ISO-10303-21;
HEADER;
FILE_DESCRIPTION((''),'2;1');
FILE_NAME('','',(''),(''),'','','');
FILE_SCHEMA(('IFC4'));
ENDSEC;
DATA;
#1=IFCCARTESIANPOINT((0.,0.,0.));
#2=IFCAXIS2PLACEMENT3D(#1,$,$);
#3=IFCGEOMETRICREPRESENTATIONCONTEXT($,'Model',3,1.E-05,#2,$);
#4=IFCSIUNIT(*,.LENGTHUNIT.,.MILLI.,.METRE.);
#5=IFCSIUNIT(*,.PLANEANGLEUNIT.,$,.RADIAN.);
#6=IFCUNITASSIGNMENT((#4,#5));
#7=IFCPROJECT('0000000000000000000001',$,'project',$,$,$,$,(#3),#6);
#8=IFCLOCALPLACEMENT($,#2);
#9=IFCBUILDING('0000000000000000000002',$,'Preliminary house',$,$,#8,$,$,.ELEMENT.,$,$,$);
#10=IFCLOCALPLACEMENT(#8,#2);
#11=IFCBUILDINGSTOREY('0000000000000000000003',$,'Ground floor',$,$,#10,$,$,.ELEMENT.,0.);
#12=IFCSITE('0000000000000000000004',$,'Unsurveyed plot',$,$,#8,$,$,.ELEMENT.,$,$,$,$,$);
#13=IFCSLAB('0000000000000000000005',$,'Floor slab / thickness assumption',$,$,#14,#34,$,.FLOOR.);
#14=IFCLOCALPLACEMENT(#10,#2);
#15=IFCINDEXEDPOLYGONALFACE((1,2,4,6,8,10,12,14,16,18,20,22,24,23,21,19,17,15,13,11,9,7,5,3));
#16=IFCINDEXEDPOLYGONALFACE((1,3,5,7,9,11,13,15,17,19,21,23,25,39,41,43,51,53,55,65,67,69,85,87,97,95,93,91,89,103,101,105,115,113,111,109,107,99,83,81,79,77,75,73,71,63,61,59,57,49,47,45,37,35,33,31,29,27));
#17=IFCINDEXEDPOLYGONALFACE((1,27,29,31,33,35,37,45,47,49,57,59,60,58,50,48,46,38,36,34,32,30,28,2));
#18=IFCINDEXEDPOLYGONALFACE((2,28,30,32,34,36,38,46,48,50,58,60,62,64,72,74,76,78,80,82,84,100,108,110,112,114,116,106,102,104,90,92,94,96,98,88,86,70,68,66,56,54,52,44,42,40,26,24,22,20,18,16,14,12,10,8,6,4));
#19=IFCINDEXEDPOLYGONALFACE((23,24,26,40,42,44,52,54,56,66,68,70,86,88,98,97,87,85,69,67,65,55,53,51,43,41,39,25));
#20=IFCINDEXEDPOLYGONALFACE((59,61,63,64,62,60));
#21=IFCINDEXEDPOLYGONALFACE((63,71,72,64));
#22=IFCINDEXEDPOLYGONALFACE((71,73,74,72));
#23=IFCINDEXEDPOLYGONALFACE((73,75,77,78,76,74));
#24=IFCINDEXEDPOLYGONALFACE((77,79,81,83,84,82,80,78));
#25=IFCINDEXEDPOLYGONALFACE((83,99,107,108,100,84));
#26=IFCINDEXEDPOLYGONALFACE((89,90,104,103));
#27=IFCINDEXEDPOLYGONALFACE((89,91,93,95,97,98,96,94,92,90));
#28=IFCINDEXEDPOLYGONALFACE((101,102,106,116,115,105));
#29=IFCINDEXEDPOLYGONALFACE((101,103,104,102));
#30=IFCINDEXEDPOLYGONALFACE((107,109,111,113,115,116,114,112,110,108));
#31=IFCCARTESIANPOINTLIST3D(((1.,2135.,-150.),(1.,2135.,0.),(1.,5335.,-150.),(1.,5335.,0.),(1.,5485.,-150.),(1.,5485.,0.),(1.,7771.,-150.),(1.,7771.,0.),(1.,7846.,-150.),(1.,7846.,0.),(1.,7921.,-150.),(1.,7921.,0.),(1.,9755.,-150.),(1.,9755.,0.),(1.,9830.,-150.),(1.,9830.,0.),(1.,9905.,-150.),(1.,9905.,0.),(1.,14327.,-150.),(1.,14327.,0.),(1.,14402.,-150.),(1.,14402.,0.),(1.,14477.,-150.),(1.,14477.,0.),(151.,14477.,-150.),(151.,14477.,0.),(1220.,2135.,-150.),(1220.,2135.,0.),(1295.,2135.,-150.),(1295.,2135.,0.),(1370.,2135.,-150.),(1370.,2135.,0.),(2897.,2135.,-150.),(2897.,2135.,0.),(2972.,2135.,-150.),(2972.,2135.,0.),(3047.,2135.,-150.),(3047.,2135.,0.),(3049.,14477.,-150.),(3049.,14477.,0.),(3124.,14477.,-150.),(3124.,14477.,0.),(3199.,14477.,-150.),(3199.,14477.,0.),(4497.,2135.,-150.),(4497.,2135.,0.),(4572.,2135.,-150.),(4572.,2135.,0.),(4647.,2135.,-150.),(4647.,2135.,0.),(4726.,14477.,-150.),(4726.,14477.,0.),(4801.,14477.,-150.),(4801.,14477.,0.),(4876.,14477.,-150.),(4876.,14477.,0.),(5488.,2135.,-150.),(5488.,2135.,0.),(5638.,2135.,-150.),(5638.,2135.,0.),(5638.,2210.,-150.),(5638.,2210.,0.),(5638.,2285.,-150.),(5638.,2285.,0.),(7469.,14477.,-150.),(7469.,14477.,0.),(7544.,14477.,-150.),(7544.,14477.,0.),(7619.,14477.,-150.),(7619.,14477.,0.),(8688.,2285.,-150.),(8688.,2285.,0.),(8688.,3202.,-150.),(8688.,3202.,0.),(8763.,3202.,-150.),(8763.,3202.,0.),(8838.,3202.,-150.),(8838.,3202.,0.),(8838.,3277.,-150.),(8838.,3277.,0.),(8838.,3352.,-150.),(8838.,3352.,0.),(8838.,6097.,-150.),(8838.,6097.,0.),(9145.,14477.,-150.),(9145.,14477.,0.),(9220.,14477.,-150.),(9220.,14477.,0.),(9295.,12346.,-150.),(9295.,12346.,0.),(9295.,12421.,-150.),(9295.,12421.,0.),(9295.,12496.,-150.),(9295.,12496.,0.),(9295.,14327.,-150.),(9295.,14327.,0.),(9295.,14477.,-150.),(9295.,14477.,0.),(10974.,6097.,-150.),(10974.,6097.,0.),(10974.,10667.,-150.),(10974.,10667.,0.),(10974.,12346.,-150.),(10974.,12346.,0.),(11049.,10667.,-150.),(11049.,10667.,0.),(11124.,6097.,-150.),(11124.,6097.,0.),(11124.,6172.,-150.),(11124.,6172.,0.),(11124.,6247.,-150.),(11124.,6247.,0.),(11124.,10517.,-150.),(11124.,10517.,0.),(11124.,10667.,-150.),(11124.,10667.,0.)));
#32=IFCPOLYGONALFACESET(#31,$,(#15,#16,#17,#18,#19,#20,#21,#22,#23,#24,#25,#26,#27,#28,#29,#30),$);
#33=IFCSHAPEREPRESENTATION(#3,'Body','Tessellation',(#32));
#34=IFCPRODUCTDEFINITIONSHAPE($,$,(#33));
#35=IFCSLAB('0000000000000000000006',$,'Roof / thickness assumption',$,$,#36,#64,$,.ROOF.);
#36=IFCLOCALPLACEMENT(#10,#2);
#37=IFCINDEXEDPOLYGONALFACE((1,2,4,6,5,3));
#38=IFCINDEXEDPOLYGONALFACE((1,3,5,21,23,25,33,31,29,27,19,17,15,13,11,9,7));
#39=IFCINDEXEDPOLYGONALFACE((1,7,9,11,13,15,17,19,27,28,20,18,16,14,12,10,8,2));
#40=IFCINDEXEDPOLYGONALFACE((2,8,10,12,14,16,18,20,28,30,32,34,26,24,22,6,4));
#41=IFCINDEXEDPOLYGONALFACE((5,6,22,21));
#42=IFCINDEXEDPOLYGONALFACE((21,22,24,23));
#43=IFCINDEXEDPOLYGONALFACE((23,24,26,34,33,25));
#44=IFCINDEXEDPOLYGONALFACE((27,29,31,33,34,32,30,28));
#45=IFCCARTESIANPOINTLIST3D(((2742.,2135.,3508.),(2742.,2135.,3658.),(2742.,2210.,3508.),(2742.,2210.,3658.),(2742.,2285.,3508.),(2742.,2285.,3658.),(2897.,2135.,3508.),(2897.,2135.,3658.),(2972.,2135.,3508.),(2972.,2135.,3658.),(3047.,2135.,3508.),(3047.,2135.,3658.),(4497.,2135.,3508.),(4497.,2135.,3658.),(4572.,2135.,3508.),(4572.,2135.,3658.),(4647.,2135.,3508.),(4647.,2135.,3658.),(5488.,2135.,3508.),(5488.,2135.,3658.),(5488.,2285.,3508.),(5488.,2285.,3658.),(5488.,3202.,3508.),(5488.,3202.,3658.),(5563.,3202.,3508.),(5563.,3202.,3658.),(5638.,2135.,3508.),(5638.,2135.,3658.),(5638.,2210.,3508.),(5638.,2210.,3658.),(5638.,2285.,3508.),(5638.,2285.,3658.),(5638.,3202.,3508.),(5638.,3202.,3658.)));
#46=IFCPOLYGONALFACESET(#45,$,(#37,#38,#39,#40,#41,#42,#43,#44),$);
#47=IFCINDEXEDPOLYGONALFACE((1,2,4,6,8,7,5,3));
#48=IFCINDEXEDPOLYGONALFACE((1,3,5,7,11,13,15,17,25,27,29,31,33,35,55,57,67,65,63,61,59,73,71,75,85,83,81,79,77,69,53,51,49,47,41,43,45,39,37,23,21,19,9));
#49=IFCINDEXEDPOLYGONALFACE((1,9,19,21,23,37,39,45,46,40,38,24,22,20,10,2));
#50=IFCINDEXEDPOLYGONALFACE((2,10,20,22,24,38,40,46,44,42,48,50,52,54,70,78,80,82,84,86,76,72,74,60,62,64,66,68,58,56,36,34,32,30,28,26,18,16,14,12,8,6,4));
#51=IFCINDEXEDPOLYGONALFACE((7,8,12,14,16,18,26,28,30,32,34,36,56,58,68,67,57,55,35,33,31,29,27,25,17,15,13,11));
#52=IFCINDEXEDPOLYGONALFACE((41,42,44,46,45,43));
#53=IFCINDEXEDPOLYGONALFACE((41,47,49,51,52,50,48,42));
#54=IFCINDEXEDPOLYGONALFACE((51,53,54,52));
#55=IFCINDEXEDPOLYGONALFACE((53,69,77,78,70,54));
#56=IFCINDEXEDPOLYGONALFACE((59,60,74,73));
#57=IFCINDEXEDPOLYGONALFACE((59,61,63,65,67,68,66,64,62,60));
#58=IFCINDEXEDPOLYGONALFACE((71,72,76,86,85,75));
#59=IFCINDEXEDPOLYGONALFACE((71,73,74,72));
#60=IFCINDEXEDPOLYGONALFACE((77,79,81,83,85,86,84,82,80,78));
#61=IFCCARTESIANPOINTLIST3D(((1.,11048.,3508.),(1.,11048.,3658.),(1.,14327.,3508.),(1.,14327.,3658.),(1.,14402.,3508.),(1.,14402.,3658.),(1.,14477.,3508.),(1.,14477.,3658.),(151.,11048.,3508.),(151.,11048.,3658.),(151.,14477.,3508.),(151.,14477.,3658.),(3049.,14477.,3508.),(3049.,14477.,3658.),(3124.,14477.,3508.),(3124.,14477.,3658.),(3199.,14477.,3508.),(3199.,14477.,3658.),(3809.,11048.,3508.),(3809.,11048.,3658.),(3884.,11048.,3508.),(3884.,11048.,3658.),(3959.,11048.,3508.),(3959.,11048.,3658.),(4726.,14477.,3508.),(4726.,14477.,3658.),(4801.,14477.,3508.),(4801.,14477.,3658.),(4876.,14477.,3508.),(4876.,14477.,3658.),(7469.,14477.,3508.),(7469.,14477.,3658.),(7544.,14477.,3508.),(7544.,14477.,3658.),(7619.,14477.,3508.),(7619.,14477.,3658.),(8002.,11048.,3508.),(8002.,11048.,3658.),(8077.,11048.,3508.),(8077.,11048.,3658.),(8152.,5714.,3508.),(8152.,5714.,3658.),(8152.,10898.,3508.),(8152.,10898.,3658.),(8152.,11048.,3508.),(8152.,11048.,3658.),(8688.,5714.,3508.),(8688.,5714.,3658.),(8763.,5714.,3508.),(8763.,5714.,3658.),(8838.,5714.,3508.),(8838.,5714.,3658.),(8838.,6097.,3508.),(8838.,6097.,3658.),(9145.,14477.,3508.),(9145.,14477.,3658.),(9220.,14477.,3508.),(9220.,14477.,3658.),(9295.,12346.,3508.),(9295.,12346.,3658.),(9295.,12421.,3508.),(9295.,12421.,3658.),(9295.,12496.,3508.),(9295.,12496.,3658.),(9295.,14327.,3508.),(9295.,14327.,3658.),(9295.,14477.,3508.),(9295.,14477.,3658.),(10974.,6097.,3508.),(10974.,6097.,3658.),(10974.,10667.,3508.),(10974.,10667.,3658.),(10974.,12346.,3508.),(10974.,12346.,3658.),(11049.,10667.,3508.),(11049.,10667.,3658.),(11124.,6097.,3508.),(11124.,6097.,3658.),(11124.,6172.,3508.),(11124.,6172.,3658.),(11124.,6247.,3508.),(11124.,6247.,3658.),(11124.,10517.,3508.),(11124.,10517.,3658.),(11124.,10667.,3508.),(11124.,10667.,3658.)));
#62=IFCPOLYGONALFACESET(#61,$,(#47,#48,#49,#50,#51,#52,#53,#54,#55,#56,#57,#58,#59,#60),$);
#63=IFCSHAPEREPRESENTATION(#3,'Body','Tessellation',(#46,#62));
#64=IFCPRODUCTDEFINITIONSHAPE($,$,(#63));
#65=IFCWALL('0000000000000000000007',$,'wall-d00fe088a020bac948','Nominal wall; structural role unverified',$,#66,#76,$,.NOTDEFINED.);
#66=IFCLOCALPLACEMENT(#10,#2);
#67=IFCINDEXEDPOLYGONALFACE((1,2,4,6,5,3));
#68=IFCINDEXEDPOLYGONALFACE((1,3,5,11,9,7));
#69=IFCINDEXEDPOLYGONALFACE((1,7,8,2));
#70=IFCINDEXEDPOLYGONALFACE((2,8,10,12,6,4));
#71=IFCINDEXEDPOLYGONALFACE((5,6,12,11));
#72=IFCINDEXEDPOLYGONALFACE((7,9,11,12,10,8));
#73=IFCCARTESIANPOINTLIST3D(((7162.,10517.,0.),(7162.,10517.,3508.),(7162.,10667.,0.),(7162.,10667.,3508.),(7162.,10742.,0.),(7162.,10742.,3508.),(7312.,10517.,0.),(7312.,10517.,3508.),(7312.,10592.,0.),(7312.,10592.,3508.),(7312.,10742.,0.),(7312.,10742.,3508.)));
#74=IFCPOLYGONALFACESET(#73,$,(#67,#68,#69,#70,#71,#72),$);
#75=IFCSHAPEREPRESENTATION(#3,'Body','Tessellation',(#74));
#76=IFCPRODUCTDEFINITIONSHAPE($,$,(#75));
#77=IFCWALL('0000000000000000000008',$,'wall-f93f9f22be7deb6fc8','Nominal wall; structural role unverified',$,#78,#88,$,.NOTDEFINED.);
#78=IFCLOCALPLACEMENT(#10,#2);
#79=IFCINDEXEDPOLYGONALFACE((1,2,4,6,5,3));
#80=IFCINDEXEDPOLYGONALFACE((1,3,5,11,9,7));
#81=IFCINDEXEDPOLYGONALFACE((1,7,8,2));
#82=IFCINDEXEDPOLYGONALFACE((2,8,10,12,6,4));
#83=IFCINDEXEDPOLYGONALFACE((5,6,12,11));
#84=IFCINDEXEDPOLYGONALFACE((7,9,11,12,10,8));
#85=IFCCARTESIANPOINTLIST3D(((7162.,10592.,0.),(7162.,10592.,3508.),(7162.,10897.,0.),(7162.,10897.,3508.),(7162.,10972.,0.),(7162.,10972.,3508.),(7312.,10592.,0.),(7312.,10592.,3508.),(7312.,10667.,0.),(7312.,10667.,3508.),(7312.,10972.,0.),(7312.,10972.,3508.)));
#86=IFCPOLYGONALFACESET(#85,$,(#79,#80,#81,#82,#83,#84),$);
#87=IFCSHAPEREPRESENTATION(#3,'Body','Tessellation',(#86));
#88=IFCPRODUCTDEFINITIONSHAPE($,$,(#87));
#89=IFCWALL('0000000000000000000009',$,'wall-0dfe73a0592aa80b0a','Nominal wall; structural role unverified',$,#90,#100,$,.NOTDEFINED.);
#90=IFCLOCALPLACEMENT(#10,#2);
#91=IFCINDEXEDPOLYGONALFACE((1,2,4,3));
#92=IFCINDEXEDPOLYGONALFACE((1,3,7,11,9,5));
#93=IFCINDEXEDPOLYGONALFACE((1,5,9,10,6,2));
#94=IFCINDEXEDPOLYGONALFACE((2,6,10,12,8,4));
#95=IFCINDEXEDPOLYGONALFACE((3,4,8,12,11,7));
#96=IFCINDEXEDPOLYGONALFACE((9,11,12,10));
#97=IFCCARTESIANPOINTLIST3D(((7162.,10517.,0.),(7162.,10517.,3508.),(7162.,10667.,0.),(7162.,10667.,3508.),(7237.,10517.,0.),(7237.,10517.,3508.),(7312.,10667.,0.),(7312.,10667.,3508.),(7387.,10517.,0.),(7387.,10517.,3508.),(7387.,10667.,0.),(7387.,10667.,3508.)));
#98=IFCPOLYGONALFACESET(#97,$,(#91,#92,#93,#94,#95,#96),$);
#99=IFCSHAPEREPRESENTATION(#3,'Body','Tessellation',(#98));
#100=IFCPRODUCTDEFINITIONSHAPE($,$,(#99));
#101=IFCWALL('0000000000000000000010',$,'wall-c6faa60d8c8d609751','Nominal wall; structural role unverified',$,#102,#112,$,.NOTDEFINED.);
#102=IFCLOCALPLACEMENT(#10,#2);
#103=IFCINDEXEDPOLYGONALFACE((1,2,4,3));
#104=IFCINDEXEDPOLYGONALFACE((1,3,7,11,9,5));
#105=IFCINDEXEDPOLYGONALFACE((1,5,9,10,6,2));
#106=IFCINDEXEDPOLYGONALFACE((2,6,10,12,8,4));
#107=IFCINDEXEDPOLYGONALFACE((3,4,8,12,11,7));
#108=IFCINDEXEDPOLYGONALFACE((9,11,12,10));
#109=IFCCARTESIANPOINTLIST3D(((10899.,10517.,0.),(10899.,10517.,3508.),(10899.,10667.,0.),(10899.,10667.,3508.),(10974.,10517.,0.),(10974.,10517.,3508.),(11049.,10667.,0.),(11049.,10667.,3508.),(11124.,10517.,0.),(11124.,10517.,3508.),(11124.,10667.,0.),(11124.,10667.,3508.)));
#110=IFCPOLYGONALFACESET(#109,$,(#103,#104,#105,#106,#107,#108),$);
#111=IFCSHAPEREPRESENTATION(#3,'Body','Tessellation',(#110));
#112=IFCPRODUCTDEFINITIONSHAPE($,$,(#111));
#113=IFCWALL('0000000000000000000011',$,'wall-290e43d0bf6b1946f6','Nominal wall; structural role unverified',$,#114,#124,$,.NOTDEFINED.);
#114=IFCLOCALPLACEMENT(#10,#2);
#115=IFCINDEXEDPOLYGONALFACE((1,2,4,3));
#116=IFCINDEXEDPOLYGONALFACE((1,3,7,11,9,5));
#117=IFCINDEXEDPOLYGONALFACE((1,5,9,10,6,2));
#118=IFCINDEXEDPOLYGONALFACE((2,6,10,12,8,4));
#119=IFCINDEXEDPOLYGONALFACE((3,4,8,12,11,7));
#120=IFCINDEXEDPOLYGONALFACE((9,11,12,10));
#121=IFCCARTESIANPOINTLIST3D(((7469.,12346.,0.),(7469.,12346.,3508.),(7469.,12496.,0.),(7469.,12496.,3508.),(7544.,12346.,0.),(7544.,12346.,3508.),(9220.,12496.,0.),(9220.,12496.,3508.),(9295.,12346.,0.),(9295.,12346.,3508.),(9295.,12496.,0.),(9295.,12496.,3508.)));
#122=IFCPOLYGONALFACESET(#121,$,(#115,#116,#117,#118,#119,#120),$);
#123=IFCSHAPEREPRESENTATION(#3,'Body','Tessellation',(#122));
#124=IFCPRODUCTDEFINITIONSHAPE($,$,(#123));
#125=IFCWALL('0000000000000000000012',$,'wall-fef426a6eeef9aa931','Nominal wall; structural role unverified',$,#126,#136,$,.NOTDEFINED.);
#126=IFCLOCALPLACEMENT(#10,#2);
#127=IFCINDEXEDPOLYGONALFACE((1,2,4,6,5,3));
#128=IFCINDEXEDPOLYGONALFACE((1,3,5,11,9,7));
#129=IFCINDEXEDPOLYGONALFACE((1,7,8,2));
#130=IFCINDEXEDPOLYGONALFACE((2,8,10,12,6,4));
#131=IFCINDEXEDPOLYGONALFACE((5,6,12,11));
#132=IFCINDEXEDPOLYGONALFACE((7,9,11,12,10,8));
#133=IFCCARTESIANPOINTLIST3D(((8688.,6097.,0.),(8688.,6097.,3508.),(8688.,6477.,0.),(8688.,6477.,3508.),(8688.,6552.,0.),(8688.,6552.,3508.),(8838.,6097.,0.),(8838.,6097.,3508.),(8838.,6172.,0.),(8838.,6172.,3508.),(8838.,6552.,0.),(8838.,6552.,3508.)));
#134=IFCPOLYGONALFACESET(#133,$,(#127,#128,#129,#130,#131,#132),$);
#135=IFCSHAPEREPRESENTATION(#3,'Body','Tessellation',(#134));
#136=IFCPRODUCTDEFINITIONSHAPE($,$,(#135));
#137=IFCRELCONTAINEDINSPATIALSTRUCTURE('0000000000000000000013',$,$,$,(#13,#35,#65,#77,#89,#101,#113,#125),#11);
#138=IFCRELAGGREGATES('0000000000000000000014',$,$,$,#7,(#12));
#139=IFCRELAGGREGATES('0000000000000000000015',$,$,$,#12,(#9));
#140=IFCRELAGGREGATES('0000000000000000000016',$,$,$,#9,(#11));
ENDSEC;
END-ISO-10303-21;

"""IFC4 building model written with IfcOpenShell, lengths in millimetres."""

from ifc_helpers import new_model, si_unit, frame, origin, place, context, project, spatial, polyline, outline, extrude, element, save


model = new_model("IFC4")

# Units and contexts
model_context = context("Model", 3, precision=1e-05, world=origin())
ifc_project = project(units=[si_unit("LENGTHUNIT", "METRE", prefix="MILLI"), si_unit("PLANEANGLEUNIT", "RADIAN")], contexts=[model_context])

# Site, building, storey
placement_1 = place(None, origin())
site = spatial("IfcSite", under=ifc_project, at=placement_1, Name="Unsurveyed plot", CompositionType="ELEMENT")
building = spatial("IfcBuilding", under=site, at=placement_1, Name="Preliminary house", CompositionType="ELEMENT")
placement_2 = place(placement_1, origin())
storey = spatial("IfcBuildingStorey", under=building, at=placement_2, Name="Ground floor", CompositionType="ELEMENT", Elevation=0.0)

# Slabs
element("IfcSlab", 1, at=placement_2, inside=storey, Name="Floor slab / thickness assumption", PredefinedType="FLOOR", context=model_context, shape_type="SweptSolid", body=[
    extrude(outline(polyline([(4497.0, 2135.0), (3047.0, 2135.0), (2972.0, 2135.0), (2897.0, 2135.0), (1370.0, 2135.0), (1295.0, 2135.0), (1220.0, 2135.0), (1.0, 2135.0), (1.0, 5335.0), (1.0, 5485.0), (1.0, 7771.0), (1.0, 7846.0), (1.0, 7921.0), (1.0, 9755.0), (1.0, 9830.0), (1.0, 9905.0), (1.0, 14327.0), (1.0, 14402.0), (1.0, 14477.0), (151.0, 14477.0), (3049.0, 14477.0), (3124.0, 14477.0), (3199.0, 14477.0), (4726.0, 14477.0), (4801.0, 14477.0), (4876.0, 14477.0), (7469.0, 14477.0), (7544.0, 14477.0), (7619.0, 14477.0), (9145.0, 14477.0), (9220.0, 14477.0), (9295.0, 14477.0), (9295.0, 14327.0), (9295.0, 12496.0), (9295.0, 12421.0), (9295.0, 12346.0), (10974.0, 12346.0), (10974.0, 10667.0), (11049.0, 10667.0), (11124.0, 10667.0), (11124.0, 10517.0), (11124.0, 6247.0), (11124.0, 6172.0), (11124.0, 6097.0), (10974.0, 6097.0), (8838.0, 6097.0), (8838.0, 3352.0), (8838.0, 3277.0), (8838.0, 3202.0), (8763.0, 3202.0), (8688.0, 3202.0), (8688.0, 2285.0), (5638.0, 2285.0), (5638.0, 2210.0), (5638.0, 2135.0), (5488.0, 2135.0), (4647.0, 2135.0), (4572.0, 2135.0), (4497.0, 2135.0)])), frame((0.0, 0.0, -150.0)), (0.0, 0.0, 1.0), 150.0),
])
element("IfcSlab", 2, at=placement_2, inside=storey, Name="Roof / thickness assumption", PredefinedType="ROOF", context=model_context, shape_type="SweptSolid", body=[
    extrude(outline(polyline([(2742.0, 2210.0), (2742.0, 2285.0), (5488.0, 2285.0), (5488.0, 3202.0), (5563.0, 3202.0), (5638.0, 3202.0), (5638.0, 2285.0), (5638.0, 2210.0), (5638.0, 2135.0), (5488.0, 2135.0), (4647.0, 2135.0), (4572.0, 2135.0), (4497.0, 2135.0), (3047.0, 2135.0), (2972.0, 2135.0), (2897.0, 2135.0), (2742.0, 2135.0), (2742.0, 2210.0)])), frame((0.0, 0.0, 3508.0)), (0.0, 0.0, 1.0), 150.0),
    extrude(outline(polyline([(1.0, 14402.0), (1.0, 14477.0), (151.0, 14477.0), (3049.0, 14477.0), (3124.0, 14477.0), (3199.0, 14477.0), (4726.0, 14477.0), (4801.0, 14477.0), (4876.0, 14477.0), (7469.0, 14477.0), (7544.0, 14477.0), (7619.0, 14477.0), (9145.0, 14477.0), (9220.0, 14477.0), (9295.0, 14477.0), (9295.0, 14327.0), (9295.0, 12496.0), (9295.0, 12421.0), (9295.0, 12346.0), (10974.0, 12346.0), (10974.0, 10667.0), (11049.0, 10667.0), (11124.0, 10667.0), (11124.0, 10517.0), (11124.0, 6247.0), (11124.0, 6172.0), (11124.0, 6097.0), (10974.0, 6097.0), (8838.0, 6097.0), (8838.0, 5714.0), (8763.0, 5714.0), (8688.0, 5714.0), (8152.0, 5714.0), (8152.0, 10898.0), (8152.0, 11048.0), (8077.0, 11048.0), (8002.0, 11048.0), (3959.0, 11048.0), (3884.0, 11048.0), (3809.0, 11048.0), (151.0, 11048.0), (1.0, 11048.0), (1.0, 14327.0), (1.0, 14402.0)])), frame((0.0, 0.0, 3508.0)), (0.0, 0.0, 1.0), 150.0),
])

# Walls
element("IfcWall", 3, at=placement_2, inside=storey, Name="wall-d00fe088a020bac948", Description="Nominal wall; structural role unverified", PredefinedType="NOTDEFINED", context=model_context, shape_type="SweptSolid", body=[
    extrude(outline(polyline([(7162.0, 10667.0), (7162.0, 10742.0), (7312.0, 10742.0), (7312.0, 10592.0), (7312.0, 10517.0), (7162.0, 10517.0), (7162.0, 10667.0)])), origin(), (0.0, 0.0, 1.0), 3508.0),
])
element("IfcWall", 4, at=placement_2, inside=storey, Name="wall-f93f9f22be7deb6fc8", Description="Nominal wall; structural role unverified", PredefinedType="NOTDEFINED", context=model_context, shape_type="SweptSolid", body=[
    extrude(outline(polyline([(7162.0, 10897.0), (7162.0, 10972.0), (7312.0, 10972.0), (7312.0, 10667.0), (7312.0, 10592.0), (7162.0, 10592.0), (7162.0, 10897.0)])), origin(), (0.0, 0.0, 1.0), 3508.0),
])
element("IfcWall", 5, at=placement_2, inside=storey, Name="wall-0dfe73a0592aa80b0a", Description="Nominal wall; structural role unverified", PredefinedType="NOTDEFINED", context=model_context, shape_type="SweptSolid", body=[
    extrude(outline(polyline([(7312.0, 10667.0), (7387.0, 10667.0), (7387.0, 10517.0), (7237.0, 10517.0), (7162.0, 10517.0), (7162.0, 10667.0), (7312.0, 10667.0)])), origin(), (0.0, 0.0, 1.0), 3508.0),
])

# Wall
element("IfcWall", 6, at=placement_2, inside=storey, Name="wall-c6faa60d8c8d609751", Description="Nominal wall; structural role unverified", PredefinedType="NOTDEFINED", context=model_context, shape_type="SweptSolid", body=[
    extrude(outline(polyline([(11049.0, 10667.0), (11124.0, 10667.0), (11124.0, 10517.0), (10974.0, 10517.0), (10899.0, 10517.0), (10899.0, 10667.0), (11049.0, 10667.0)])), origin(), (0.0, 0.0, 1.0), 3508.0),
])

# Wall
element("IfcWall", 7, at=placement_2, inside=storey, Name="wall-290e43d0bf6b1946f6", Description="Nominal wall; structural role unverified", PredefinedType="NOTDEFINED", context=model_context, shape_type="SweptSolid", body=[
    extrude(outline(polyline([(9220.0, 12496.0), (9295.0, 12496.0), (9295.0, 12346.0), (7544.0, 12346.0), (7469.0, 12346.0), (7469.0, 12496.0), (9220.0, 12496.0)])), origin(), (0.0, 0.0, 1.0), 3508.0),
])

# Wall
element("IfcWall", 8, at=placement_2, inside=storey, Name="wall-fef426a6eeef9aa931", Description="Nominal wall; structural role unverified", PredefinedType="NOTDEFINED", context=model_context, shape_type="SweptSolid", body=[
    extrude(outline(polyline([(8688.0, 6477.0), (8688.0, 6552.0), (8838.0, 6552.0), (8838.0, 6172.0), (8838.0, 6097.0), (8688.0, 6097.0), (8688.0, 6477.0)])), origin(), (0.0, 0.0, 1.0), 3508.0),
])

save(model, "model.ifc")
